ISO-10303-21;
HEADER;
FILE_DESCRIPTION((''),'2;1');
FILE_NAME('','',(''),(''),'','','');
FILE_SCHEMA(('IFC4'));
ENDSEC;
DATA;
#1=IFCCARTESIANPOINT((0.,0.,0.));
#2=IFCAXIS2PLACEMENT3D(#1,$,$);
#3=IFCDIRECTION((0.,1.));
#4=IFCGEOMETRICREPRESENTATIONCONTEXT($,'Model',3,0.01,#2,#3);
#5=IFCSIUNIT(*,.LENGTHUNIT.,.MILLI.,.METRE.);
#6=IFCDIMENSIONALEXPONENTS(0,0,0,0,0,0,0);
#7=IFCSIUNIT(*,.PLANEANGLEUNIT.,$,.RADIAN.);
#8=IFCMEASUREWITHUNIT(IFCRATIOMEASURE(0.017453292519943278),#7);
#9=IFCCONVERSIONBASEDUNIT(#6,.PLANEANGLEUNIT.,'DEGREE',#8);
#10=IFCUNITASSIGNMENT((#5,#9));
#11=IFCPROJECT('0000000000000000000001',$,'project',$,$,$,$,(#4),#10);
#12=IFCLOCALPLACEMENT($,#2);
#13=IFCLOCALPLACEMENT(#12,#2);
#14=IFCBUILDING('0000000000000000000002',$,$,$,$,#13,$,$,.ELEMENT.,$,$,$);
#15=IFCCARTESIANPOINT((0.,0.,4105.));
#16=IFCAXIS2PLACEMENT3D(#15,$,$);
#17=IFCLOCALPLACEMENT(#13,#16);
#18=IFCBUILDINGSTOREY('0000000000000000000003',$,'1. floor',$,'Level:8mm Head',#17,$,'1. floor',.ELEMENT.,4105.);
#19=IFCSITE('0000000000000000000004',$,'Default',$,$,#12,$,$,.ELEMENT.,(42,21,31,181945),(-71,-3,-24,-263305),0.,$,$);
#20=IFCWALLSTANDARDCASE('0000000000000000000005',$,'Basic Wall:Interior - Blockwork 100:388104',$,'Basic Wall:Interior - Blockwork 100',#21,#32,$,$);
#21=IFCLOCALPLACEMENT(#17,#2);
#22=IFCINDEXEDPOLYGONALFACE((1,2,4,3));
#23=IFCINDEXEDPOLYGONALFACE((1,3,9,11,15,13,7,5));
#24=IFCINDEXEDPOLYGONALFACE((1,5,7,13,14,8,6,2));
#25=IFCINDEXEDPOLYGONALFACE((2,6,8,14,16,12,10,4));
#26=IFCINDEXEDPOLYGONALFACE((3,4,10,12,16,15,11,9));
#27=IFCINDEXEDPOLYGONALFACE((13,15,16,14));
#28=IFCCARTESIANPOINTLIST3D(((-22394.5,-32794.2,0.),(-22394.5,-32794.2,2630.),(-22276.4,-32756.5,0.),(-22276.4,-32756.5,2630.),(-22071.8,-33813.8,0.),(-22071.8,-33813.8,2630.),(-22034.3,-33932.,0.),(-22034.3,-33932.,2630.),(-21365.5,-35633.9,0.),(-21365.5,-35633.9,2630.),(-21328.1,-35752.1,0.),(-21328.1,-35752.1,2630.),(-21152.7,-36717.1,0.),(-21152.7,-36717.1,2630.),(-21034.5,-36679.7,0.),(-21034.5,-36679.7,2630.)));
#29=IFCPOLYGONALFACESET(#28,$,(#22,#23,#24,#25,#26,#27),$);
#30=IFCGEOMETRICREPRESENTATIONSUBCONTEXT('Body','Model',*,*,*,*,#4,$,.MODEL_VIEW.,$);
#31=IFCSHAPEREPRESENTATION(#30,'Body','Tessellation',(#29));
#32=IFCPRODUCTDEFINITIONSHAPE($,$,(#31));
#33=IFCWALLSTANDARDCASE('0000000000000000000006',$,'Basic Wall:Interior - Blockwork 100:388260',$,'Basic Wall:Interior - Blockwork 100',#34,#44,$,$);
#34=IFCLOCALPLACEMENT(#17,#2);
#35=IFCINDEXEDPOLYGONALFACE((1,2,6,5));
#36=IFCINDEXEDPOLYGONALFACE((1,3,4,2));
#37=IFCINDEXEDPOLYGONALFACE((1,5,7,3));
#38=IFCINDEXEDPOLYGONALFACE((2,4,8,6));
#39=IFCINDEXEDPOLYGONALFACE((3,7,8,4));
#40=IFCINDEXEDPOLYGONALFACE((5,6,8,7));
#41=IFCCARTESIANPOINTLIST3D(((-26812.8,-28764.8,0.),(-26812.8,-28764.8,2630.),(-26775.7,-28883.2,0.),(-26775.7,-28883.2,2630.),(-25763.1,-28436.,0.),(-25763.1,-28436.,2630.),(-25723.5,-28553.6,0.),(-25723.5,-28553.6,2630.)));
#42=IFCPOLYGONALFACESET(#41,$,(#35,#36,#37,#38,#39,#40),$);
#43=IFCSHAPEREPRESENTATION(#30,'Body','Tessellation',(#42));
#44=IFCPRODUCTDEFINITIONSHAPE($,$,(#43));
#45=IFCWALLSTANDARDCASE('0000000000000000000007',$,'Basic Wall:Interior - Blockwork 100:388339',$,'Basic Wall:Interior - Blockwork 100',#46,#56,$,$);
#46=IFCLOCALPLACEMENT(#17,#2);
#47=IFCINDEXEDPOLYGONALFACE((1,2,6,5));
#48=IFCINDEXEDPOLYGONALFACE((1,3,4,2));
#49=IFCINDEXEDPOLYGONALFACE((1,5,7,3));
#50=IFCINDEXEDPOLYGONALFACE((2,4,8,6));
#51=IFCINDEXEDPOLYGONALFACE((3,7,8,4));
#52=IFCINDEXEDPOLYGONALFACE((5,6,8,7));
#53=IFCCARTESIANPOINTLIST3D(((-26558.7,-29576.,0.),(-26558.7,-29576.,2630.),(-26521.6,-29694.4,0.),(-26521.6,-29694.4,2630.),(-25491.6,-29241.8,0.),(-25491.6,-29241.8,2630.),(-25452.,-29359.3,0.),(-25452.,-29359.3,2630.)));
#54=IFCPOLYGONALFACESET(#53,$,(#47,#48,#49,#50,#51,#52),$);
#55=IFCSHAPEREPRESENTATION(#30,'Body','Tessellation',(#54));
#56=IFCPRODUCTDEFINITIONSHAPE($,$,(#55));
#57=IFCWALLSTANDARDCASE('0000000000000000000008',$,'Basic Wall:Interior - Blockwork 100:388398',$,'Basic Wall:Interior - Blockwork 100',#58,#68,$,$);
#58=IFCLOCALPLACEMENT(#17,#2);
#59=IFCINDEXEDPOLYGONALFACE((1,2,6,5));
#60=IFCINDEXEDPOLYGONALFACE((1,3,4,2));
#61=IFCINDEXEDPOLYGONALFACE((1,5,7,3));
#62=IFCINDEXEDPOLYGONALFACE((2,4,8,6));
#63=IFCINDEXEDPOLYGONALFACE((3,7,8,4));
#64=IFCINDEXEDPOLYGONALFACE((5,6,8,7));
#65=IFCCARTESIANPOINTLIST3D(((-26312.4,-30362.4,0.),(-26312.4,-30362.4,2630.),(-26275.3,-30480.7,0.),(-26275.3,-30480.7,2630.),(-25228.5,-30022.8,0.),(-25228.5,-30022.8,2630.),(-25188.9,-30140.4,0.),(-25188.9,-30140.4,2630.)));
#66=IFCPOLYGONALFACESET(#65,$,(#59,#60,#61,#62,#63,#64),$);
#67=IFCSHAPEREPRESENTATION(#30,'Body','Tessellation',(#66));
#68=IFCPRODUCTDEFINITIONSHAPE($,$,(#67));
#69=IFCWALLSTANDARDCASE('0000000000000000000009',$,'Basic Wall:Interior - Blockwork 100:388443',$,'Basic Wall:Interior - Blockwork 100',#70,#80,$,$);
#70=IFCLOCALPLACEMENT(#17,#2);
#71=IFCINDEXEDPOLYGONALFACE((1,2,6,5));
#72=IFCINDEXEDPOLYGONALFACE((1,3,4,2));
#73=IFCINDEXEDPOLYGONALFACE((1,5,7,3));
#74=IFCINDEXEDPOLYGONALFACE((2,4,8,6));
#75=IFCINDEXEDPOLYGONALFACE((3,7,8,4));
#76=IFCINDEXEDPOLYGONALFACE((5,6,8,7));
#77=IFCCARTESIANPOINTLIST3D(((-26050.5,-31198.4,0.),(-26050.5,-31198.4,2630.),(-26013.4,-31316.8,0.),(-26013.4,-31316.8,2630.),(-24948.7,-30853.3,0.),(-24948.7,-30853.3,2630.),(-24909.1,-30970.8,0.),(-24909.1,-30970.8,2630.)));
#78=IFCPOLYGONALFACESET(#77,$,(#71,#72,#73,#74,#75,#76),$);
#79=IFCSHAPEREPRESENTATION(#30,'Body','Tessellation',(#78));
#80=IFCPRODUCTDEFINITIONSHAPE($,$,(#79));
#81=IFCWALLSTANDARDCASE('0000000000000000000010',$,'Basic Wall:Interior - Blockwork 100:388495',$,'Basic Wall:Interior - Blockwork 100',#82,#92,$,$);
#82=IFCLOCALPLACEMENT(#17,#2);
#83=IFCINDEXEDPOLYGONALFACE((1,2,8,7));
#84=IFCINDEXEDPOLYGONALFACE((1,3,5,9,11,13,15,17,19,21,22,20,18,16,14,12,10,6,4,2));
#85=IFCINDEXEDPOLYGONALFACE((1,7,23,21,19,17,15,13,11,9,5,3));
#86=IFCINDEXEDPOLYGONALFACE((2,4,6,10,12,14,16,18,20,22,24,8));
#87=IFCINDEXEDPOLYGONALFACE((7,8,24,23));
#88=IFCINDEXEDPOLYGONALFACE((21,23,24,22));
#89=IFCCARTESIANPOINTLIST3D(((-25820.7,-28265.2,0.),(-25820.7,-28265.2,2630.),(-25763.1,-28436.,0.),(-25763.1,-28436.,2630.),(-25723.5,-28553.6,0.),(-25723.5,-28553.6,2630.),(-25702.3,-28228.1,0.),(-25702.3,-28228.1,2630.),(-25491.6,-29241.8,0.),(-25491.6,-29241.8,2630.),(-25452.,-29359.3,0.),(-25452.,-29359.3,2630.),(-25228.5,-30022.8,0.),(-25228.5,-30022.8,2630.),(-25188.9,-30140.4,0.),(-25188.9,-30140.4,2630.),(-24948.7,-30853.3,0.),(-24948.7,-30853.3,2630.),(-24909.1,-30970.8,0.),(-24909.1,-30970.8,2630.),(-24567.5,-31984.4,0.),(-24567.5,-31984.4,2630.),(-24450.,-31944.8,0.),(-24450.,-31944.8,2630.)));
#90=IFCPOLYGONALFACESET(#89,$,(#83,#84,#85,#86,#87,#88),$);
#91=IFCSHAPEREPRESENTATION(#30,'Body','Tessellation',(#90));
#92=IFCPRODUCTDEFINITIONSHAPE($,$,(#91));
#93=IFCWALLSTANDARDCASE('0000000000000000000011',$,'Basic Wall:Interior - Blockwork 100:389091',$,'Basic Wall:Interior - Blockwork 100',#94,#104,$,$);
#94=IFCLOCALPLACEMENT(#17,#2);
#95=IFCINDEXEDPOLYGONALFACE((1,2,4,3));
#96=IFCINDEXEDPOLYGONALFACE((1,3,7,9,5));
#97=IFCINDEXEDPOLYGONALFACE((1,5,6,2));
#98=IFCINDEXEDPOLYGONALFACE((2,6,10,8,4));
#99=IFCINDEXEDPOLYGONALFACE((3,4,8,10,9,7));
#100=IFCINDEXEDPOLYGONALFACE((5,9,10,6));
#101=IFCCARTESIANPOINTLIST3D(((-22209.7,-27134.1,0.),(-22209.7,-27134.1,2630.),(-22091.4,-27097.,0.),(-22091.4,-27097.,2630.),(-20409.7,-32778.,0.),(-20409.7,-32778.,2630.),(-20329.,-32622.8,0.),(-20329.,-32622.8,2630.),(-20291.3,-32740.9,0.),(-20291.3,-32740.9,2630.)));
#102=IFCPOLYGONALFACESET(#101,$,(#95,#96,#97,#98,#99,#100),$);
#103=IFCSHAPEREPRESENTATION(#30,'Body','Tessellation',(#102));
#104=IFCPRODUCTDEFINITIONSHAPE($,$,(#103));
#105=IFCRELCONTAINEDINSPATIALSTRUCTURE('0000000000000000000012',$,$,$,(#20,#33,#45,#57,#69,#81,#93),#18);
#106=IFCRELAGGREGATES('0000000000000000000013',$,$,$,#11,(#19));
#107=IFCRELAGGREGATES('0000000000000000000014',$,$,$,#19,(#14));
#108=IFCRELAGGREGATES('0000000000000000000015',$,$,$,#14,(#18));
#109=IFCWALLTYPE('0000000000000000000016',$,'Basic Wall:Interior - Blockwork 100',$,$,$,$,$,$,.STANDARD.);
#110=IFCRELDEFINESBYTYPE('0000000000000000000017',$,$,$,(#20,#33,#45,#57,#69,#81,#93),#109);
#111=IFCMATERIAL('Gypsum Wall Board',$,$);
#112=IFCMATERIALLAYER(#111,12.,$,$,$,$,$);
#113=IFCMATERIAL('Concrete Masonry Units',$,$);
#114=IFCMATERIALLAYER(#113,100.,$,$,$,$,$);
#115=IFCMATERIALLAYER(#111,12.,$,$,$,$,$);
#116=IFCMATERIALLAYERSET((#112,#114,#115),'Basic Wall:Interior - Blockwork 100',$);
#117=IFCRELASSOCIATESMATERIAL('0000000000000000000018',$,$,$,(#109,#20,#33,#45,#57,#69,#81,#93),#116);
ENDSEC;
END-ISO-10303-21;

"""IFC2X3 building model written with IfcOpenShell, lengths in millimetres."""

from ifc_helpers import new_model, entity, si_unit, converted_unit, direction, frame, origin, place, context, subcontext, project, spatial, polyline, outline, extrude, material, layer, layer_set, layer_usage, type_object, element, save


model = new_model("IFC2X3")

# Units and contexts
model_context = context("Model", 3, precision=0.01, world=origin(), true_north=direction((0.0, 1.0)))
body_context = subcontext(model_context, "Body", "Model", "MODEL_VIEW")
ifc_project = project(units=[si_unit("LENGTHUNIT", "METRE", prefix="MILLI"), converted_unit("PLANEANGLEUNIT", "DEGREE", entity("IfcRatioMeasure", 0.017453292519943278), si_unit("PLANEANGLEUNIT", "RADIAN"), dimensions=[0, 0, 0, 0, 0, 0, 0])], contexts=[model_context])

# Site, building, storey
site_placement = place(None, origin())
site = spatial("IfcSite", under=ifc_project, at=site_placement, Name="Default", CompositionType="ELEMENT", RefLatitude=(42, 21, 31, 181945), RefLongitude=(-71, -3, -24, -263305), RefElevation=0.0)
building_placement = place(site_placement, origin())
building = spatial("IfcBuilding", under=site, at=building_placement, CompositionType="ELEMENT")
storey_placement = place(building_placement, frame((0.0, 0.0, 4105.0)))
storey = spatial("IfcBuildingStorey", under=building, at=storey_placement, Name="1. floor", ObjectType="Level:8mm Head", LongName="1. floor", CompositionType="ELEMENT", Elevation=4105.0)

# Shared definitions
ifc_material_1 = material(Name="Gypsum Wall Board")
ifc_layer_1 = layer(ifc_material_1, 12.0)
ifc_material_2 = material(Name="Concrete Masonry Units")
ifc_layer_2 = layer(ifc_material_2, 100.0)
ifc_layer_3 = layer(ifc_material_1, 12.0)
ifc_layer_set = layer_set([ifc_layer_1, ifc_layer_2, ifc_layer_3], Name="Basic Wall:Interior - Blockwork 100")
wall_type = type_object("IfcWallType", Name="Basic Wall:Interior - Blockwork 100", PredefinedType="STANDARD", material=ifc_layer_set)

# Wall
ifc_layer_usage_1 = layer_usage(ifc_layer_set, "AXIS2", "NEGATIVE", 62.0)
wall_1_placement = place(storey_placement, frame((-22335.5, -32775.2, 0.0), z_axis=(0.0, 0.0, 1.0), x_axis=(0.301797, -0.953372, 0.0)))
element("IfcWallStandardCase", 1, at=wall_1_placement, inside=storey, type_object=wall_type, material=ifc_layer_usage_1, Name="Basic Wall:Interior - Blockwork 100:388104", ObjectType="Basic Wall:Interior - Blockwork 100", context=body_context, shape_type="SweptSolid", body=[
    extrude(outline(polyline([(4115.0, -62.0), (4115.0, 62.0), (3142.1, 62.0), (3018.1, 62.0), (0.0, 62.0), (0.3, -62.0), (1069.7, -62.0), (1193.7, -62.0), (4115.0, -62.0)])), origin(), (0.0, 0.0, 1.0), 2630.0),
])

# Walls
ifc_layer_usage_2 = layer_usage(ifc_layer_set, "AXIS2", "NEGATIVE", 62.0)
wall_2_placement = place(storey_placement, frame((-26794.3, -28824.0, 0.0), z_axis=(0.0, 0.0, 1.0), x_axis=(0.954277, 0.298924, 0.0)))
element("IfcWallStandardCase", 2, at=wall_2_placement, inside=storey, type_object=wall_type, material=ifc_layer_usage_2, Name="Basic Wall:Interior - Blockwork 100:388260", ObjectType="Basic Wall:Interior - Blockwork 100", context=body_context, shape_type="SweptSolid", body=[
    extrude(outline(polyline([(1102.6, -62.0), (1100.0, 62.0), (0.0, 62.0), (0.0, -62.0), (1102.6, -62.0)])), origin(), (0.0, 0.0, 1.0), 2630.0),
])
ifc_layer_usage_3 = layer_usage(ifc_layer_set, "AXIS2", "NEGATIVE", 62.0)
wall_3_placement = place(storey_placement, frame((-26540.1, -29635.2, 0.0), z_axis=(0.0, 0.0, 1.0), x_axis=(0.954277, 0.298924, 0.0)))
element("IfcWallStandardCase", 3, at=wall_3_placement, inside=storey, type_object=wall_type, material=ifc_layer_usage_3, Name="Basic Wall:Interior - Blockwork 100:388339", ObjectType="Basic Wall:Interior - Blockwork 100", context=body_context, shape_type="SweptSolid", body=[
    extrude(outline(polyline([(1120.8, -62.0), (1118.2, 62.0), (0.0, 62.0), (0.0, -62.0), (1120.8, -62.0)])), origin(), (0.0, 0.0, 1.0), 2630.0),
])
ifc_layer_usage_4 = layer_usage(ifc_layer_set, "AXIS2", "NEGATIVE", 62.0)
wall_4_placement = place(storey_placement, frame((-26293.8, -30421.5, 0.0), z_axis=(0.0, 0.0, 1.0), x_axis=(0.954277, 0.298924, 0.0)))
element("IfcWallStandardCase", 4, at=wall_4_placement, inside=storey, type_object=wall_type, material=ifc_layer_usage_4, Name="Basic Wall:Interior - Blockwork 100:388398", ObjectType="Basic Wall:Interior - Blockwork 100", context=body_context, shape_type="SweptSolid", body=[
    extrude(outline(polyline([(1138.5, -62.0), (1135.8, 62.0), (0.0, 62.0), (0.0, -62.0), (1138.5, -62.0)])), origin(), (0.0, 0.0, 1.0), 2630.0),
])
ifc_layer_usage_5 = layer_usage(ifc_layer_set, "AXIS2", "NEGATIVE", 62.0)
wall_5_placement = place(storey_placement, frame((-26031.9, -31257.6, 0.0), z_axis=(0.0, 0.0, 1.0), x_axis=(0.954277, 0.298924, 0.0)))
element("IfcWallStandardCase", 5, at=wall_5_placement, inside=storey, type_object=wall_type, material=ifc_layer_usage_5, Name="Basic Wall:Interior - Blockwork 100:388443", ObjectType="Basic Wall:Interior - Blockwork 100", context=body_context, shape_type="SweptSolid", body=[
    extrude(outline(polyline([(1157.3, -62.0), (1154.6, 62.0), (0.0, 62.0), (0.0, -62.0), (1157.3, -62.0)])), origin(), (0.0, 0.0, 1.0), 2630.0),
])
ifc_layer_usage_6 = layer_usage(ifc_layer_set, "AXIS2", "NEGATIVE", 62.0)
wall_6_placement = place(storey_placement, frame((-25761.9, -28245.4, 0.0), z_axis=(0.0, 0.0, 1.0), x_axis=(0.319293, -0.947656, 0.0)))
element("IfcWallStandardCase", 6, at=wall_6_placement, inside=storey, type_object=wall_type, material=ifc_layer_usage_6, Name="Basic Wall:Interior - Blockwork 100:388495", ObjectType="Basic Wall:Interior - Blockwork 100", context=body_context, shape_type="SweptSolid", body=[
    extrude(outline(polyline([(3924.7, -62.0), (3924.7, 62.0), (2.7, 62.0), (0.0, -62.0), (180.3, -62.0), (304.3, -62.0), (1030.6, -62.0), (1154.6, -62.0), (1854.7, -62.0), (1978.8, -62.0), (2731.1, -62.0), (2855.1, -62.0), (3924.7, -62.0)])), origin(), (0.0, 0.0, 1.0), 2630.0),
])
ifc_layer_usage_7 = layer_usage(ifc_layer_set, "AXIS2", "NEGATIVE", 62.0)
wall_7_placement = place(storey_placement, frame((-22150.6, -27115.2, 0.0), z_axis=(0.0, 0.0, 1.0), x_axis=(0.303856, -0.952718, 0.0)))
element("IfcWallStandardCase", 7, at=wall_7_placement, inside=storey, type_object=wall_type, material=ifc_layer_usage_7, Name="Basic Wall:Interior - Blockwork 100:389091", ObjectType="Basic Wall:Interior - Blockwork 100", context=body_context, shape_type="SweptSolid", body=[
    extrude(outline(polyline([(5924.0, -62.0), (5924.6, 62.0), (5800.6, 62.0), (0.6, 62.0), (0.0, -62.0), (5924.0, -62.0)])), origin(), (0.0, 0.0, 1.0), 2630.0),
])

save(model, "model.ifc")
